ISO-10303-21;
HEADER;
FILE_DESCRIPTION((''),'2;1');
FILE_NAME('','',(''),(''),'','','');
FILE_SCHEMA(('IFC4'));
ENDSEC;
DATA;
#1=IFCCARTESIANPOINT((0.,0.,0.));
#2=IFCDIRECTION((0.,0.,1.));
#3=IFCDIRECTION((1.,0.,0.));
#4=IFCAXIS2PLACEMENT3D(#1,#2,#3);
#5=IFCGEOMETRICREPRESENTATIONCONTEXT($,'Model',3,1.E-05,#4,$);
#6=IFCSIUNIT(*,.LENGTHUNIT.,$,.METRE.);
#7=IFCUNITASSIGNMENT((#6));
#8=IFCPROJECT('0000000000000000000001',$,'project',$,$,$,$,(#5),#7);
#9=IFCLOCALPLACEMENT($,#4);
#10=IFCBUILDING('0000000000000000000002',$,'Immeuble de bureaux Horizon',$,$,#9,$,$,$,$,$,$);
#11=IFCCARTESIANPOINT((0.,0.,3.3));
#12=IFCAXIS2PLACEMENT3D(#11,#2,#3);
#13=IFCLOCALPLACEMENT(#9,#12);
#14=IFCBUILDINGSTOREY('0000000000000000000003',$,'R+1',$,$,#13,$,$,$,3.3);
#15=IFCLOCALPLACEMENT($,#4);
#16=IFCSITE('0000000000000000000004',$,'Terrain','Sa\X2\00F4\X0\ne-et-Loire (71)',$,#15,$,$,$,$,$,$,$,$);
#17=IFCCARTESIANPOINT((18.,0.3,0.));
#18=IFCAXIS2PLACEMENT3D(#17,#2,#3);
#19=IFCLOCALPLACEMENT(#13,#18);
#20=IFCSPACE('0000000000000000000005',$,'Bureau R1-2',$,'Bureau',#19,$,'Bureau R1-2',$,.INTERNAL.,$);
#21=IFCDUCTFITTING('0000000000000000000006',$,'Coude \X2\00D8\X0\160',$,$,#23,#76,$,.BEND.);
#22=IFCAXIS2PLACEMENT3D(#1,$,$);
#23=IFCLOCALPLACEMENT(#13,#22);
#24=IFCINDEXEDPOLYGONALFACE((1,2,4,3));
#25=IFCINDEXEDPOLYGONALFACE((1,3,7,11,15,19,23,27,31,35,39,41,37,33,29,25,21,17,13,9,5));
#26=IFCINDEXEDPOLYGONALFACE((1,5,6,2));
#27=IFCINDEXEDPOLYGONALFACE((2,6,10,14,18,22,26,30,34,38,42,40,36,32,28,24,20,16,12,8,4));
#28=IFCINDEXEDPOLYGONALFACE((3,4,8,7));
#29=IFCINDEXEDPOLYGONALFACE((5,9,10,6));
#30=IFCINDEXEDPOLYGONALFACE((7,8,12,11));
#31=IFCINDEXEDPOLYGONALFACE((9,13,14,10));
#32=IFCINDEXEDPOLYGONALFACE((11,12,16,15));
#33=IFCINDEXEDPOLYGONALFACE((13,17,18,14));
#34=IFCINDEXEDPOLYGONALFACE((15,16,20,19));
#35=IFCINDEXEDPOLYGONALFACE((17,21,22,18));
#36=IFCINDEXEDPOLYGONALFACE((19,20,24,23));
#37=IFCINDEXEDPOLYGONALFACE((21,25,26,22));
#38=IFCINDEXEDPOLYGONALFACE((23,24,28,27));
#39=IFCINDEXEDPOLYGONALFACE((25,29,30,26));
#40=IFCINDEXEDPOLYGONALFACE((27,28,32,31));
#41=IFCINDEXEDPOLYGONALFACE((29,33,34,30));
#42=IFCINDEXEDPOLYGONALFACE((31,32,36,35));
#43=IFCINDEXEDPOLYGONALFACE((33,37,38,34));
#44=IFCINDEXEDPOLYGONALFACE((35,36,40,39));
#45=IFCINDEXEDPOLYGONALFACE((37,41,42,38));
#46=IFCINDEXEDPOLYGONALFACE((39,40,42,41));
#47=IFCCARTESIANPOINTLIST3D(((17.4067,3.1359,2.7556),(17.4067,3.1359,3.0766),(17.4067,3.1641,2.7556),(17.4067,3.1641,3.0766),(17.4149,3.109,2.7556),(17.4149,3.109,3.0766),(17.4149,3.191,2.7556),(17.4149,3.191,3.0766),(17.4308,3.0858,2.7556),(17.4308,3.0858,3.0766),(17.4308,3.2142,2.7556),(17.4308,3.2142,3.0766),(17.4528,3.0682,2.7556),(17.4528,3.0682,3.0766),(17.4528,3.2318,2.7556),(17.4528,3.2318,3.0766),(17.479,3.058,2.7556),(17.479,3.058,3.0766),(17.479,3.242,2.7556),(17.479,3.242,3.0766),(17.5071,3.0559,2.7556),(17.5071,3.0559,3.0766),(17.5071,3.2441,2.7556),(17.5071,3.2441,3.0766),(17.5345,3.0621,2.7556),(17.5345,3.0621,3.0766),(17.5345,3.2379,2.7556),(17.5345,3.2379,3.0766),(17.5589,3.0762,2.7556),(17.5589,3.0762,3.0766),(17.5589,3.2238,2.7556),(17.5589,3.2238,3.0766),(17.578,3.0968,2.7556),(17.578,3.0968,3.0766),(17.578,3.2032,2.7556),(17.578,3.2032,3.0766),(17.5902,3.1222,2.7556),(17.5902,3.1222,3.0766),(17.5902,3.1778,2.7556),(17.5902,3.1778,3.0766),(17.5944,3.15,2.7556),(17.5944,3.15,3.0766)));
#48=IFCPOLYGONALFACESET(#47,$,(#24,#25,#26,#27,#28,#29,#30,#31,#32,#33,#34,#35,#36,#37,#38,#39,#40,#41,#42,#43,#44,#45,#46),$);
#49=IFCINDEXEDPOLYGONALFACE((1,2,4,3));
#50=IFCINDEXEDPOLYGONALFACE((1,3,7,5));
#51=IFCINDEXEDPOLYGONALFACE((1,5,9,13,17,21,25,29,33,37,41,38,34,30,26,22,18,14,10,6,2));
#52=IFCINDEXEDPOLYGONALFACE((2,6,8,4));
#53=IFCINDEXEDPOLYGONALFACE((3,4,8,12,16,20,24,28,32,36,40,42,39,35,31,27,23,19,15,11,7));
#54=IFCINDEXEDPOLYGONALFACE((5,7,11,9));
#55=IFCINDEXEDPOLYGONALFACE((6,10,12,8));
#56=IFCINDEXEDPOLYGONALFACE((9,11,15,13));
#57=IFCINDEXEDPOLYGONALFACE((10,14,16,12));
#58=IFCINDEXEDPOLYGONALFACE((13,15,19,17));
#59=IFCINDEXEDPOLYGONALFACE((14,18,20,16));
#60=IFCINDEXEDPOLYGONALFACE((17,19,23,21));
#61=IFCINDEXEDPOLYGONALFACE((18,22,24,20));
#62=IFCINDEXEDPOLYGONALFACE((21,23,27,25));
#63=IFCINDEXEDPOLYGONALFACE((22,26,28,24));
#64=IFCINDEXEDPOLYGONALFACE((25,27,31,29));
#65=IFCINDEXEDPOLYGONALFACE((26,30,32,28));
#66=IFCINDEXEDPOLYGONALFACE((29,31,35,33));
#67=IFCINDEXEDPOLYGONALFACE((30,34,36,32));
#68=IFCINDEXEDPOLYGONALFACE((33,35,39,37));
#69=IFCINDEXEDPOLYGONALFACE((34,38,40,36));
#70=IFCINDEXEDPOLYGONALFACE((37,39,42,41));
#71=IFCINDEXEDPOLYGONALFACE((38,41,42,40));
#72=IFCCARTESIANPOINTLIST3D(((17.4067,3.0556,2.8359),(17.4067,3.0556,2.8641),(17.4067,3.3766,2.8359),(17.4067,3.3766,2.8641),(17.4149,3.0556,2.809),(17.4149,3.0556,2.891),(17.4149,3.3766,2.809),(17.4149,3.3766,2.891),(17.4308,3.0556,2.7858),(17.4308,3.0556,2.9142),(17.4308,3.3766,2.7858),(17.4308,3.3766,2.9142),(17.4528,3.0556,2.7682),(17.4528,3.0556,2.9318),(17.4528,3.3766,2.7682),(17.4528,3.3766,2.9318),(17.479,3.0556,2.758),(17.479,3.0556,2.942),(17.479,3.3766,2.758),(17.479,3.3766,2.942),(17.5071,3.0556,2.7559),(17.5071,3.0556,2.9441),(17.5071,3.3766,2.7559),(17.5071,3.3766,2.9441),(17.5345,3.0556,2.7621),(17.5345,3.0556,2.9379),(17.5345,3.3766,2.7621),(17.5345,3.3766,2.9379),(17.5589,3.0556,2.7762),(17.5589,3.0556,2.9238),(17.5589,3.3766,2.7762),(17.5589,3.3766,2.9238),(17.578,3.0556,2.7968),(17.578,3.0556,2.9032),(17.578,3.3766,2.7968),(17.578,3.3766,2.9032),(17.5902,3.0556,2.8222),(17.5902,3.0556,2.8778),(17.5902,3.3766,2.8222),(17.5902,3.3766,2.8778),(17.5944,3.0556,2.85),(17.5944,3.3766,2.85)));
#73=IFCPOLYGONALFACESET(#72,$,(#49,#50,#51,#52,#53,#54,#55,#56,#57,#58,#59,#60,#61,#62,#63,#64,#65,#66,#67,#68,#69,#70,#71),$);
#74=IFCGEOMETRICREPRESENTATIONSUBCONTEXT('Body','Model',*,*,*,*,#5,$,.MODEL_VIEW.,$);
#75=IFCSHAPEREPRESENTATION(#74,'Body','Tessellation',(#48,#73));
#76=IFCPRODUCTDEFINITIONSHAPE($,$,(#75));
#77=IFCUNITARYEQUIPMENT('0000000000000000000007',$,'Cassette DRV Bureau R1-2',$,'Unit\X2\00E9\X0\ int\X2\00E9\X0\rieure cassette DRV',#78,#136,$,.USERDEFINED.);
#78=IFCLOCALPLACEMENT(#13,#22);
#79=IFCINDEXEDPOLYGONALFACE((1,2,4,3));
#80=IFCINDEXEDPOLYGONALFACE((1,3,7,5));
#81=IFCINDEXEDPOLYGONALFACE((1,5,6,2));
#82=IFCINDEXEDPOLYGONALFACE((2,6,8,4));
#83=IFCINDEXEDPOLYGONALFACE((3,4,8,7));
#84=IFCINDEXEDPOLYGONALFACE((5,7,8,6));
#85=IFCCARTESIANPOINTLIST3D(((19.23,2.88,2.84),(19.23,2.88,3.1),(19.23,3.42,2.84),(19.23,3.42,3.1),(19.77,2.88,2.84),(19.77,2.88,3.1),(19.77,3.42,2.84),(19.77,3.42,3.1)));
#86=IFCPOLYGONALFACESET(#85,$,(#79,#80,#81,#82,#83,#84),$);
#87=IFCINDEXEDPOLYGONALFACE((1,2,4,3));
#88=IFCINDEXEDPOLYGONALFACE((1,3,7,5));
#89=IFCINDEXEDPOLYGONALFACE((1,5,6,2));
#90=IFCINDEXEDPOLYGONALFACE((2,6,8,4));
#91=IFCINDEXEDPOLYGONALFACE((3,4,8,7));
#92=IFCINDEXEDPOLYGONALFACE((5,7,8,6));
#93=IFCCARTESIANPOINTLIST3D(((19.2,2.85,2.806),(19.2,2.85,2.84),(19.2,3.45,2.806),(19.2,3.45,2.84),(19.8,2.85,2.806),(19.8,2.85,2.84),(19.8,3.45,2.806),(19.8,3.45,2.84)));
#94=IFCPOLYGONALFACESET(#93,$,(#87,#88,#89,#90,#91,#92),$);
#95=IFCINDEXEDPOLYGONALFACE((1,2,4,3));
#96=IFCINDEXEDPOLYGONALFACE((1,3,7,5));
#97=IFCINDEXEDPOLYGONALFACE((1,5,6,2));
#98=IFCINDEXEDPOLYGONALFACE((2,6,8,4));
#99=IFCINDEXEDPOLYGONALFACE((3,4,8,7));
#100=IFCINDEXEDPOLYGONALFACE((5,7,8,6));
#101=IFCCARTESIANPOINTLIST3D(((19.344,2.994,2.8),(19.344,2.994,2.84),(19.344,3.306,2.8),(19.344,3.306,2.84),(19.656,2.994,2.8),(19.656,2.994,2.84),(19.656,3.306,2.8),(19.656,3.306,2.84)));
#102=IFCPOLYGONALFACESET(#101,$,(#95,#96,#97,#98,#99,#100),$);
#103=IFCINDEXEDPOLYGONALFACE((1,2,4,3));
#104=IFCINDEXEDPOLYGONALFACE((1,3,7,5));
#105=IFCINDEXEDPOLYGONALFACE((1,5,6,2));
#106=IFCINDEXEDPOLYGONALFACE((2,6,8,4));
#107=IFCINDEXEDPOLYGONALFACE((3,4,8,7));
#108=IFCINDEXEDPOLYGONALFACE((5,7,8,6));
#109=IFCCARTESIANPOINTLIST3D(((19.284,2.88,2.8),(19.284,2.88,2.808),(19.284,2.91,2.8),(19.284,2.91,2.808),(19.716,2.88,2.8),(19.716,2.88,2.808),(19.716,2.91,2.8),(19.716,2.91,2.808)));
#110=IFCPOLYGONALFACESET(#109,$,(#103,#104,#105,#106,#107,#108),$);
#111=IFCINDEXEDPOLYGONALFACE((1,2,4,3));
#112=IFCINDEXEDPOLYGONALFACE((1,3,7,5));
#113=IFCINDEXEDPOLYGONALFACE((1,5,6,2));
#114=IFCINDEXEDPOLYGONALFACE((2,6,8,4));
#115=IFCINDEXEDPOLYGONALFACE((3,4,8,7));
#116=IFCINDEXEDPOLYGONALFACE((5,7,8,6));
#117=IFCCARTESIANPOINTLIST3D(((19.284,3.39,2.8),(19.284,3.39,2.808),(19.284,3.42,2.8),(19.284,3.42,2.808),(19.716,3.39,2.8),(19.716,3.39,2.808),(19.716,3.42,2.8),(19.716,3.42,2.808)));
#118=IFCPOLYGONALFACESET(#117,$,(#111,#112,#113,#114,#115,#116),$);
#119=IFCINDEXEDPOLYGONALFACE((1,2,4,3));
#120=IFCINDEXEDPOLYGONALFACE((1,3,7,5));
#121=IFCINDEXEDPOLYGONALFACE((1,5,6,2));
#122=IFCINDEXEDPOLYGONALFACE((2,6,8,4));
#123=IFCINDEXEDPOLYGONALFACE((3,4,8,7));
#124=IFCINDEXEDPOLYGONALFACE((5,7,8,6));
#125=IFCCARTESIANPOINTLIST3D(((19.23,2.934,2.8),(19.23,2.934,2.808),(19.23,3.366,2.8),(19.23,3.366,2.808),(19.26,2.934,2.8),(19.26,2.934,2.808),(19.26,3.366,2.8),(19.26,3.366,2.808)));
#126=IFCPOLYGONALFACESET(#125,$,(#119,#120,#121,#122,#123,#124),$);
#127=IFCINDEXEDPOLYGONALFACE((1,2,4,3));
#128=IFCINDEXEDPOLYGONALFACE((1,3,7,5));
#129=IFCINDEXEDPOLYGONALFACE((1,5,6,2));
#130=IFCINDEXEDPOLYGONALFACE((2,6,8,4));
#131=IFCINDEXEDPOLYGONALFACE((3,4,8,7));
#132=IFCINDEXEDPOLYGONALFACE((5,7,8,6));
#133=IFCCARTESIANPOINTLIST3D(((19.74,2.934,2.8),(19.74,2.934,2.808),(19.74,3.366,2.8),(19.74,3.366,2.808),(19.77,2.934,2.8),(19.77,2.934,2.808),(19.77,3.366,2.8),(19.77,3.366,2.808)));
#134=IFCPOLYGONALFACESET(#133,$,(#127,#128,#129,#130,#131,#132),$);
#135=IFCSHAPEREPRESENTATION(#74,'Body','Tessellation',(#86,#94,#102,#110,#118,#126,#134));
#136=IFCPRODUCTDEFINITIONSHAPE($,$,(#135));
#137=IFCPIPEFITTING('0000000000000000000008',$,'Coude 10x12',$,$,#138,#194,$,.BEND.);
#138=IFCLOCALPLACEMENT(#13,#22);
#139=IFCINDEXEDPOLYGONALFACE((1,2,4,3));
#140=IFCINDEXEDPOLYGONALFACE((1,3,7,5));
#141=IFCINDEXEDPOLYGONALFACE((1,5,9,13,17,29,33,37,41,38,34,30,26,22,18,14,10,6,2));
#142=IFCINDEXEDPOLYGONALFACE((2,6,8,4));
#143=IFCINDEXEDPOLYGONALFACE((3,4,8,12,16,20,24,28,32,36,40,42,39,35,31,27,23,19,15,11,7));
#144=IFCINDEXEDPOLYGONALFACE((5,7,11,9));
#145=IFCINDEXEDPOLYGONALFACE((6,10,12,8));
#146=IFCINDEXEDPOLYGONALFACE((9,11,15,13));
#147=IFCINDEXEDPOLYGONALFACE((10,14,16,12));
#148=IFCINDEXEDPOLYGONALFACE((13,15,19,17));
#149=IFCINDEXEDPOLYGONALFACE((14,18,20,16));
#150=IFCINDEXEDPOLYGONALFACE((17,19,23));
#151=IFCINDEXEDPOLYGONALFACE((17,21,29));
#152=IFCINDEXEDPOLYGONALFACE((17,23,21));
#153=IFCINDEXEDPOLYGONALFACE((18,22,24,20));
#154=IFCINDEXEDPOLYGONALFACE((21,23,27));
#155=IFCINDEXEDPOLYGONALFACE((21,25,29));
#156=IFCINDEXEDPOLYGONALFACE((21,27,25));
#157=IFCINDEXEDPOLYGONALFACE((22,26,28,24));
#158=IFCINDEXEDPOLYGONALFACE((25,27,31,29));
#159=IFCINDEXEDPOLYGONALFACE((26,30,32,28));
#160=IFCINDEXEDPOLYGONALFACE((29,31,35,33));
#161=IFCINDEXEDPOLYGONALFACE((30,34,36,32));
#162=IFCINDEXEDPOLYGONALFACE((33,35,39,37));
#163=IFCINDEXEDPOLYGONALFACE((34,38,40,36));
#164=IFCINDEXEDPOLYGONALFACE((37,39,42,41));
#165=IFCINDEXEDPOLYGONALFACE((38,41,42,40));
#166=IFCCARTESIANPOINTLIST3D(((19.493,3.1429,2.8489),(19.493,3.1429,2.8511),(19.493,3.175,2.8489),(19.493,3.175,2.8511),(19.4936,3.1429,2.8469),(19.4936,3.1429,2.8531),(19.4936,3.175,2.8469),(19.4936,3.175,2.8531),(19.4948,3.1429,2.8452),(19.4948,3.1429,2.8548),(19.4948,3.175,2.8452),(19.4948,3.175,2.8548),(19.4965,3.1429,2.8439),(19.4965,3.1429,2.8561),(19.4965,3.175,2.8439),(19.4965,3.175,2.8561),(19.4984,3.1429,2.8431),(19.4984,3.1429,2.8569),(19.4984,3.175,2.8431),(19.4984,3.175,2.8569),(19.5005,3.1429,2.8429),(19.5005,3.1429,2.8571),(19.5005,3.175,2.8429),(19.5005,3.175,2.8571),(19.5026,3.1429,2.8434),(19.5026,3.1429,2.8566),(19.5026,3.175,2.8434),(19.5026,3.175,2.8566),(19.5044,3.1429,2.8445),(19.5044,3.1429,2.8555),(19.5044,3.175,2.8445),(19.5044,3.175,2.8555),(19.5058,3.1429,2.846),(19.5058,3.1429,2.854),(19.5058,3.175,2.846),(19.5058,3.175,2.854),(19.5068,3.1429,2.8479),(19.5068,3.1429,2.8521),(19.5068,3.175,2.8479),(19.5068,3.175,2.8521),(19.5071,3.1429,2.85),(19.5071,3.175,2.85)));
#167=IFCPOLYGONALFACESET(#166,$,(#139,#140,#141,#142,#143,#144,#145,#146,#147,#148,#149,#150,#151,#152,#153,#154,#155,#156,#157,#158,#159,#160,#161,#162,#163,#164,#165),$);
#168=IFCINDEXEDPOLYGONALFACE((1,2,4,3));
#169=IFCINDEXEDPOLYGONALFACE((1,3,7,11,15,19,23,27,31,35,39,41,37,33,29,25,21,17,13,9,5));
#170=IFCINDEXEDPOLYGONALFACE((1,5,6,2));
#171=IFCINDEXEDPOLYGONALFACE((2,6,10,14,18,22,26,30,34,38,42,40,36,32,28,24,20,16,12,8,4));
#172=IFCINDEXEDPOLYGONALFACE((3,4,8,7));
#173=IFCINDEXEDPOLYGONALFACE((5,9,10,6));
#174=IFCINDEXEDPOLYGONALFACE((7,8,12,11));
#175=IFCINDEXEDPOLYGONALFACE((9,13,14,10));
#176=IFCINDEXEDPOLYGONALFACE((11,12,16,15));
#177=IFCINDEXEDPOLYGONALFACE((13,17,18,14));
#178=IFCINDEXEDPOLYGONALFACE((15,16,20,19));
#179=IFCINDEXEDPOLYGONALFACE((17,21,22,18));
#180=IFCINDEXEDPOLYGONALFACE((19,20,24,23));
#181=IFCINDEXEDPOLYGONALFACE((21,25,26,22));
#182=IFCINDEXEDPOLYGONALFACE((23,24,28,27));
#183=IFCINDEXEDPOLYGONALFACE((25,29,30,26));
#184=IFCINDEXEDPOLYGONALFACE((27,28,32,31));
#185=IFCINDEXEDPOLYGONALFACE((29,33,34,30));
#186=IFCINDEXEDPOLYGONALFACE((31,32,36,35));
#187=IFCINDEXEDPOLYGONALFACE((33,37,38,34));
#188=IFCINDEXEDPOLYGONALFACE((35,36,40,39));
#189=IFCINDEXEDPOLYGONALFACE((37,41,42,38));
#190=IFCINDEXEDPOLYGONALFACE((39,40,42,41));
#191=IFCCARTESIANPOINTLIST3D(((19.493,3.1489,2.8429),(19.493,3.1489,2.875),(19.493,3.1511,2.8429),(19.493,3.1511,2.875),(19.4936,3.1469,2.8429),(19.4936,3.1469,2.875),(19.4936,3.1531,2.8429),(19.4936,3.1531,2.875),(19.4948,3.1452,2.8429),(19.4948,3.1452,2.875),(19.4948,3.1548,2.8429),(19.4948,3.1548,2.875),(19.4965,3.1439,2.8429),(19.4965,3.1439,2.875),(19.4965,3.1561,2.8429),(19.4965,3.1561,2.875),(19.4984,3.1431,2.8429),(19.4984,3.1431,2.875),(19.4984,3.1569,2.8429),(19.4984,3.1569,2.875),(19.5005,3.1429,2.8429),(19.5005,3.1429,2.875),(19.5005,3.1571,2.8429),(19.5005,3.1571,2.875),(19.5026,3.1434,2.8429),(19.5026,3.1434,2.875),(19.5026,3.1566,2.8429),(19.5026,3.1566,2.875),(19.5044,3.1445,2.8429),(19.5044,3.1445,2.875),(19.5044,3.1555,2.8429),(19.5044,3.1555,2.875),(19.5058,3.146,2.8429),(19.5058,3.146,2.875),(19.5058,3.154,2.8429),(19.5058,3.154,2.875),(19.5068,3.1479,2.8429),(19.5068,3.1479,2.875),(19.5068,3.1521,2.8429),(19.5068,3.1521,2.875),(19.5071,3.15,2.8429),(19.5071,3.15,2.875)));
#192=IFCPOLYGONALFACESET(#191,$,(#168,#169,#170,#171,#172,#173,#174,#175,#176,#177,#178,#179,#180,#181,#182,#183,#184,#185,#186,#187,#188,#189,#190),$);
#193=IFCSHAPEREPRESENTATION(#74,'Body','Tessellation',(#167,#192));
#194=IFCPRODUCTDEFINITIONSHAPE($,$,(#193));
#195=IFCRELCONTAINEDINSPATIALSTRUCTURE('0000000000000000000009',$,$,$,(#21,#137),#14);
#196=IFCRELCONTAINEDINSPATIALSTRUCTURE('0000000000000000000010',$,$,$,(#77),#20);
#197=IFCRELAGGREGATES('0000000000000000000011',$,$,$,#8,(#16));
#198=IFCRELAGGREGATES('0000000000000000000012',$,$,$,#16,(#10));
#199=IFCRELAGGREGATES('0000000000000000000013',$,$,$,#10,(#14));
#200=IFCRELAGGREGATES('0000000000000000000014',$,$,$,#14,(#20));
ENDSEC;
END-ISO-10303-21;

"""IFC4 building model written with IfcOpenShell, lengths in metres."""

from ifc_helpers import new_model, si_unit, frame, frame_2d, origin_with_axes, place, context, subcontext, project, spatial, rectangle, circle, extrude, element, save


model = new_model("IFC4")

# Units and contexts
model_context = context("Model", 3, precision=1e-05, world=origin_with_axes())
body_context = subcontext(model_context, "Body", "Model", "MODEL_VIEW")
ifc_project = project(units=[si_unit("LENGTHUNIT", "METRE")], contexts=[model_context])

# Site, building, storey
site_placement = place(None, origin_with_axes())
site = spatial("IfcSite", under=ifc_project, at=site_placement, Name="Terrain", Description="Saône-et-Loire (71)")
building_placement = place(None, origin_with_axes())
building = spatial("IfcBuilding", under=site, at=building_placement, Name="Immeuble de bureaux Horizon")
storey_placement = place(building_placement, frame((0.0, 0.0, 3.3), z_axis=(0.0, 0.0, 1.0), x_axis=(1.0, 0.0, 0.0)))
storey = spatial("IfcBuildingStorey", under=building, at=storey_placement, Name="R+1", Elevation=3.3)

# Duct fitting
duct_fitting_1_placement = place(storey_placement, frame((17.5, 3.15, 2.85), z_axis=(0.0, 0.0, 1.0), x_axis=(1.0, 0.0, 0.0)))
element("IfcDuctFitting", 1, at=duct_fitting_1_placement, inside=storey, Name="Coude Ø160", PredefinedType="BEND", context=body_context, shape_type="SweptSolid", body=[
    extrude(circle(Radius=0.0944), frame((0.0, 0.0, -0.0944), z_axis=(0.0, 0.0, 1.0), x_axis=(1.0, 0.0, 0.0)), (0.0, 0.0, 1.0), 0.321),
    extrude(circle(Radius=0.0944), frame((0.0, -0.0944, 0.0), z_axis=(0.0, 1.0, 0.0), x_axis=(1.0, 0.0, 0.0)), (0.0, 0.0, 1.0), 0.321),
])

# Shared definitions
space_1_placement = place(storey_placement, frame((18.0, 0.3, 0.0), z_axis=(0.0, 0.0, 1.0), x_axis=(1.0, 0.0, 0.0)))
space_1 = spatial("IfcSpace", under=storey, at=space_1_placement, Name="Bureau R1-2", ObjectType="Bureau", LongName="Bureau R1-2", PredefinedType="INTERNAL")

# Unitary equipment
unitary_equipment_1_placement = place(space_1_placement, frame((1.2, 2.55, 2.8), z_axis=(0.0, 0.0, 1.0), x_axis=(1.0, 0.0, 0.0)))
element("IfcUnitaryEquipment", 2, at=unitary_equipment_1_placement, inside=space_1, Name="Cassette DRV Bureau R1-2", ObjectType="Unité intérieure cassette DRV", PredefinedType="USERDEFINED", context=body_context, shape_type="SweptSolid", body=[
    extrude(rectangle(XDim=0.54, YDim=0.54, at=frame_2d((0.27, 0.27))), frame((0.03, 0.03, 0.04), z_axis=(0.0, 0.0, 1.0), x_axis=(1.0, 0.0, 0.0)), (0.0, 0.0, 1.0), 0.26),
    extrude(rectangle(XDim=0.6, YDim=0.6, at=frame_2d((0.3, 0.3))), frame((0.0, 0.0, 0.006), z_axis=(0.0, 0.0, 1.0), x_axis=(1.0, 0.0, 0.0)), (0.0, 0.0, 1.0), 0.034),
    extrude(rectangle(XDim=0.312, YDim=0.312, at=frame_2d((0.156, 0.156))), frame((0.144, 0.144, 0.0), z_axis=(0.0, 0.0, 1.0), x_axis=(1.0, 0.0, 0.0)), (0.0, 0.0, 1.0), 0.04),
    extrude(rectangle(XDim=0.432, YDim=0.03, at=frame_2d((0.216, 0.015))), frame((0.084, 0.03, 0.0), z_axis=(0.0, 0.0, 1.0), x_axis=(1.0, 0.0, 0.0)), (0.0, 0.0, 1.0), 0.008),
    extrude(rectangle(XDim=0.432, YDim=0.03, at=frame_2d((0.216, 0.015))), frame((0.084, 0.54, 0.0), z_axis=(0.0, 0.0, 1.0), x_axis=(1.0, 0.0, 0.0)), (0.0, 0.0, 1.0), 0.008),
    extrude(rectangle(XDim=0.03, YDim=0.432, at=frame_2d((0.015, 0.216))), frame((0.03, 0.084, 0.0), z_axis=(0.0, 0.0, 1.0), x_axis=(1.0, 0.0, 0.0)), (0.0, 0.0, 1.0), 0.008),
    extrude(rectangle(XDim=0.03, YDim=0.432, at=frame_2d((0.015, 0.216))), frame((0.54, 0.084, 0.0), z_axis=(0.0, 0.0, 1.0), x_axis=(1.0, 0.0, 0.0)), (0.0, 0.0, 1.0), 0.008),
])

# Pipe fitting
pipe_fitting_1_placement = place(storey_placement, frame((19.5, 3.15, 2.85), z_axis=(0.0, 0.0, 1.0), x_axis=(1.0, 0.0, 0.0)))
element("IfcPipeFitting", 3, at=pipe_fitting_1_placement, inside=storey, Name="Coude 10x12", PredefinedType="BEND", context=body_context, shape_type="SweptSolid", body=[
    extrude(circle(Radius=0.0071), frame((0.0, -0.0071, 0.0), z_axis=(0.0, 1.0, 0.0), x_axis=(1.0, 0.0, 0.0)), (0.0, 0.0, 1.0), 0.0321),
    extrude(circle(Radius=0.0071), frame((0.0, 0.0, -0.0071), z_axis=(0.0, 0.0, 1.0), x_axis=(1.0, 0.0, 0.0)), (0.0, 0.0, 1.0), 0.0321),
])

save(model, "model.ifc")
